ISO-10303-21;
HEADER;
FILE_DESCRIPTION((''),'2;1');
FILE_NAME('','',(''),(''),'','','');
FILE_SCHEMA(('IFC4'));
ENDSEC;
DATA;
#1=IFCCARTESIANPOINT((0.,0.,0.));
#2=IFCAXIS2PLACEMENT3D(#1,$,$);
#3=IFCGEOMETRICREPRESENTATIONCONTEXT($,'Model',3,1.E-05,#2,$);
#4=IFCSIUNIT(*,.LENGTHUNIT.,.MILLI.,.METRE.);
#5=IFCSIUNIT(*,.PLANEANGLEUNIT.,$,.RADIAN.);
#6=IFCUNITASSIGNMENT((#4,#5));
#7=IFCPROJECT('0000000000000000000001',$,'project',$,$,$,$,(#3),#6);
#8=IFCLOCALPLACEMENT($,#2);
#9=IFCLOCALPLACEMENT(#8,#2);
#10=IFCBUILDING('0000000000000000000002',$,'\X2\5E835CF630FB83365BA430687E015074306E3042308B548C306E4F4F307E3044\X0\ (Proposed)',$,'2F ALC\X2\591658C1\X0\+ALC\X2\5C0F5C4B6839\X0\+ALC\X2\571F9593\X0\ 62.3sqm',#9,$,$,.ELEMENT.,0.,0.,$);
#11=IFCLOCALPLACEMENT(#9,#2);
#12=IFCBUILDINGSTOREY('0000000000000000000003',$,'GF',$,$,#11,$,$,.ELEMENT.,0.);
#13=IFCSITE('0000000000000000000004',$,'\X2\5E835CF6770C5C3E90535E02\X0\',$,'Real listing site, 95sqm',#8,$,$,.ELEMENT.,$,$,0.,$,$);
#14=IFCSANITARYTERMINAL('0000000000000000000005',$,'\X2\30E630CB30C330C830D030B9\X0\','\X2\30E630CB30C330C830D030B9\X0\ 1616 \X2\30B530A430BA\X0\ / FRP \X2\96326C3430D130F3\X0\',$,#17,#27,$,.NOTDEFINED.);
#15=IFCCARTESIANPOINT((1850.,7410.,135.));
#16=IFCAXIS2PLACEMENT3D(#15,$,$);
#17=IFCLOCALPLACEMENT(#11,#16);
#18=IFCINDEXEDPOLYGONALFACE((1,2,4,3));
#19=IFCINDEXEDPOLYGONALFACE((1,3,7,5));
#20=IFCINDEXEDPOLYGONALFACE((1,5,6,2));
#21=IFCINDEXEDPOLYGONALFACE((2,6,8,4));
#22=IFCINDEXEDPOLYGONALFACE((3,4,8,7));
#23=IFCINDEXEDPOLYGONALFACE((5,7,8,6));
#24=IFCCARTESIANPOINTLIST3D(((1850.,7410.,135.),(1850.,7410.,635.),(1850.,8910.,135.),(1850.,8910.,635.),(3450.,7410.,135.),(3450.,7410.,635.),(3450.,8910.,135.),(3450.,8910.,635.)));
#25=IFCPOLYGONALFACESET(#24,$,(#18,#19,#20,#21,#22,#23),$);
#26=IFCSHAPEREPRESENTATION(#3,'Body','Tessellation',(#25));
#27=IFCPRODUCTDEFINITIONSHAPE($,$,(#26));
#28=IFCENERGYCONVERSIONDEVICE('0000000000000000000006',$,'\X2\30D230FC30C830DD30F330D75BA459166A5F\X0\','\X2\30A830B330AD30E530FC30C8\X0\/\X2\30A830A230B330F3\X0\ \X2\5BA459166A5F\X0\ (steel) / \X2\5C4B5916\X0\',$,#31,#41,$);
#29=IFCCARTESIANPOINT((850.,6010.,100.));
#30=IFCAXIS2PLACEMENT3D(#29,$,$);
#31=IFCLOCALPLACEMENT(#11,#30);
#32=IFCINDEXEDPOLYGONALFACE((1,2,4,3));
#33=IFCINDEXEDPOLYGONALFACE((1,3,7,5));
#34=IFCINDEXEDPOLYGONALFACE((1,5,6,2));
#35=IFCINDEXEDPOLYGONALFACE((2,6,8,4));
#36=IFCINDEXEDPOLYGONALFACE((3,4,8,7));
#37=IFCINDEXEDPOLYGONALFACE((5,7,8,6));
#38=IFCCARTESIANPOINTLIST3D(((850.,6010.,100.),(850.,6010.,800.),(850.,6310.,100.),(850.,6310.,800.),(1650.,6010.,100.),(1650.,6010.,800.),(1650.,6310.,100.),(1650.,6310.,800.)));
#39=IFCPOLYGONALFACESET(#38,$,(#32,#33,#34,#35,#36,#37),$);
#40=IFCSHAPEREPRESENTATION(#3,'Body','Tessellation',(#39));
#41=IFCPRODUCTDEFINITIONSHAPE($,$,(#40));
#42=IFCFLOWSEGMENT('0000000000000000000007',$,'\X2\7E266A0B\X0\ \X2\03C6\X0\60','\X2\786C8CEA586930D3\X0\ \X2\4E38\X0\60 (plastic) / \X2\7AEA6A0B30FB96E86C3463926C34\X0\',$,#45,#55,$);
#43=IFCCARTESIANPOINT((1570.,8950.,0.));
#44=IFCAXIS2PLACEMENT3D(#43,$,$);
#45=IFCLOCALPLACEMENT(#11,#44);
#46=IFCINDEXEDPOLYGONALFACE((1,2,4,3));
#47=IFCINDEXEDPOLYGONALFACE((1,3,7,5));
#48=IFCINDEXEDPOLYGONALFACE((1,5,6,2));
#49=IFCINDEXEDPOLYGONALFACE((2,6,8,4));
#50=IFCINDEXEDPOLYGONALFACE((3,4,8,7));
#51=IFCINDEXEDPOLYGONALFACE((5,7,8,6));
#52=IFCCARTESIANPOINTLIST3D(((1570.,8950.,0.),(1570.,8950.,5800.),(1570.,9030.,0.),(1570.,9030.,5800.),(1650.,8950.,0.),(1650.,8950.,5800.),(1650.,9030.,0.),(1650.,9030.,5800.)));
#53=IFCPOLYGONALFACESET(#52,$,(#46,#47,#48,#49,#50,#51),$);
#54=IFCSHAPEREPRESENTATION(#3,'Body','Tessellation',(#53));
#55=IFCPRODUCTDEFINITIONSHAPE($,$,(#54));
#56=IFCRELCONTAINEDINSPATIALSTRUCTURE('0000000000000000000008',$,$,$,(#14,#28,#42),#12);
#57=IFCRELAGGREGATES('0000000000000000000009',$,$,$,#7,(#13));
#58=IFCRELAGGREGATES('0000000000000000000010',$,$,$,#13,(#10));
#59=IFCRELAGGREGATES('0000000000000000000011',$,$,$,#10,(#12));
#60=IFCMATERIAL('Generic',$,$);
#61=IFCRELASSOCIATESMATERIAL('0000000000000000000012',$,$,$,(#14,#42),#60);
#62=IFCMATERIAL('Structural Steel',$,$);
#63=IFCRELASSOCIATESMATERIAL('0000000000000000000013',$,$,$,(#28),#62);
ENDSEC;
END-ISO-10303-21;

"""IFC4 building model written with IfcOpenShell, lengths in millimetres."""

from ifc_helpers import new_model, si_unit, frame, frame_2d, origin, place, context, project, spatial, rectangle, extrude, material, element, save


model = new_model("IFC4")

# Units and contexts
model_context = context("Model", 3, precision=1e-05, world=origin())
ifc_project = project(units=[si_unit("LENGTHUNIT", "METRE", prefix="MILLI"), si_unit("PLANEANGLEUNIT", "RADIAN")], contexts=[model_context])

# Site, building, storey
site_placement = place(None, origin())
site = spatial("IfcSite", under=ifc_project, at=site_placement, Name="広島県尾道市", ObjectType="Real listing site, 95sqm", CompositionType="ELEMENT", RefElevation=0.0)
building_placement = place(site_placement, origin())
building = spatial("IfcBuilding", under=site, at=building_placement, Name="広島・茶室と縁側のある和の住まい (Proposed)", ObjectType="2F ALC外壁+ALC小屋根+ALC土間 62.3sqm", CompositionType="ELEMENT", ElevationOfRefHeight=0.0, ElevationOfTerrain=0.0)
storey_placement = place(building_placement, origin())
storey = spatial("IfcBuildingStorey", under=building, at=storey_placement, Name="GF", CompositionType="ELEMENT", Elevation=0.0)

# Shared definitions
ifc_material_1 = material(Name="Generic")

# Sanitary terminal
sanitary_terminal_placement = place(storey_placement, frame((1850.0, 7410.0, 135.0)))
element("IfcSanitaryTerminal", 1, at=sanitary_terminal_placement, inside=storey, material=ifc_material_1, Name="ユニットバス", Description="ユニットバス 1616 サイズ / FRP 防水パン", PredefinedType="NOTDEFINED", context=model_context, shape_type="SweptSolid", body=[
    extrude(rectangle(XDim=1600.0, YDim=1500.0, at=frame_2d((800.0, 750.0))), frame((1850.0, 7410.0, 135.0)), (0.0, 0.0, 1.0), 500.0),
])

# Energy conversion device
ifc_material_2 = material(Name="Structural Steel")
energy_conversion_device_placement = place(storey_placement, frame((850.0, 6010.0, 100.0)))
element("IfcEnergyConversionDevice", 2, at=energy_conversion_device_placement, inside=storey, material=ifc_material_2, Name="ヒートポンプ室外機", Description="エコキュート/エアコン 室外機 (steel) / 屋外", context=model_context, shape_type="SweptSolid", body=[
    extrude(rectangle(XDim=800.0, YDim=300.0, at=frame_2d((400.0, 150.0))), frame((850.0, 6010.0, 100.0)), (0.0, 0.0, 1.0), 700.0),
])

# Flow segment
flow_segment_placement = place(storey_placement, frame((1570.0, 8950.0, 0.0)))
element("IfcFlowSegment", 3, at=flow_segment_placement, inside=storey, material=ifc_material_1, Name="縦樋 φ60", Description="硬質塩ビ 丸60 (plastic) / 竪樋・雨水排水", context=model_context, shape_type="SweptSolid", body=[
    extrude(rectangle(XDim=80.0, YDim=80.0, at=frame_2d((40.0, 40.0))), frame((1570.0, 8950.0, 0.0)), (0.0, 0.0, 1.0), 5800.0),
])

save(model, "model.ifc")
